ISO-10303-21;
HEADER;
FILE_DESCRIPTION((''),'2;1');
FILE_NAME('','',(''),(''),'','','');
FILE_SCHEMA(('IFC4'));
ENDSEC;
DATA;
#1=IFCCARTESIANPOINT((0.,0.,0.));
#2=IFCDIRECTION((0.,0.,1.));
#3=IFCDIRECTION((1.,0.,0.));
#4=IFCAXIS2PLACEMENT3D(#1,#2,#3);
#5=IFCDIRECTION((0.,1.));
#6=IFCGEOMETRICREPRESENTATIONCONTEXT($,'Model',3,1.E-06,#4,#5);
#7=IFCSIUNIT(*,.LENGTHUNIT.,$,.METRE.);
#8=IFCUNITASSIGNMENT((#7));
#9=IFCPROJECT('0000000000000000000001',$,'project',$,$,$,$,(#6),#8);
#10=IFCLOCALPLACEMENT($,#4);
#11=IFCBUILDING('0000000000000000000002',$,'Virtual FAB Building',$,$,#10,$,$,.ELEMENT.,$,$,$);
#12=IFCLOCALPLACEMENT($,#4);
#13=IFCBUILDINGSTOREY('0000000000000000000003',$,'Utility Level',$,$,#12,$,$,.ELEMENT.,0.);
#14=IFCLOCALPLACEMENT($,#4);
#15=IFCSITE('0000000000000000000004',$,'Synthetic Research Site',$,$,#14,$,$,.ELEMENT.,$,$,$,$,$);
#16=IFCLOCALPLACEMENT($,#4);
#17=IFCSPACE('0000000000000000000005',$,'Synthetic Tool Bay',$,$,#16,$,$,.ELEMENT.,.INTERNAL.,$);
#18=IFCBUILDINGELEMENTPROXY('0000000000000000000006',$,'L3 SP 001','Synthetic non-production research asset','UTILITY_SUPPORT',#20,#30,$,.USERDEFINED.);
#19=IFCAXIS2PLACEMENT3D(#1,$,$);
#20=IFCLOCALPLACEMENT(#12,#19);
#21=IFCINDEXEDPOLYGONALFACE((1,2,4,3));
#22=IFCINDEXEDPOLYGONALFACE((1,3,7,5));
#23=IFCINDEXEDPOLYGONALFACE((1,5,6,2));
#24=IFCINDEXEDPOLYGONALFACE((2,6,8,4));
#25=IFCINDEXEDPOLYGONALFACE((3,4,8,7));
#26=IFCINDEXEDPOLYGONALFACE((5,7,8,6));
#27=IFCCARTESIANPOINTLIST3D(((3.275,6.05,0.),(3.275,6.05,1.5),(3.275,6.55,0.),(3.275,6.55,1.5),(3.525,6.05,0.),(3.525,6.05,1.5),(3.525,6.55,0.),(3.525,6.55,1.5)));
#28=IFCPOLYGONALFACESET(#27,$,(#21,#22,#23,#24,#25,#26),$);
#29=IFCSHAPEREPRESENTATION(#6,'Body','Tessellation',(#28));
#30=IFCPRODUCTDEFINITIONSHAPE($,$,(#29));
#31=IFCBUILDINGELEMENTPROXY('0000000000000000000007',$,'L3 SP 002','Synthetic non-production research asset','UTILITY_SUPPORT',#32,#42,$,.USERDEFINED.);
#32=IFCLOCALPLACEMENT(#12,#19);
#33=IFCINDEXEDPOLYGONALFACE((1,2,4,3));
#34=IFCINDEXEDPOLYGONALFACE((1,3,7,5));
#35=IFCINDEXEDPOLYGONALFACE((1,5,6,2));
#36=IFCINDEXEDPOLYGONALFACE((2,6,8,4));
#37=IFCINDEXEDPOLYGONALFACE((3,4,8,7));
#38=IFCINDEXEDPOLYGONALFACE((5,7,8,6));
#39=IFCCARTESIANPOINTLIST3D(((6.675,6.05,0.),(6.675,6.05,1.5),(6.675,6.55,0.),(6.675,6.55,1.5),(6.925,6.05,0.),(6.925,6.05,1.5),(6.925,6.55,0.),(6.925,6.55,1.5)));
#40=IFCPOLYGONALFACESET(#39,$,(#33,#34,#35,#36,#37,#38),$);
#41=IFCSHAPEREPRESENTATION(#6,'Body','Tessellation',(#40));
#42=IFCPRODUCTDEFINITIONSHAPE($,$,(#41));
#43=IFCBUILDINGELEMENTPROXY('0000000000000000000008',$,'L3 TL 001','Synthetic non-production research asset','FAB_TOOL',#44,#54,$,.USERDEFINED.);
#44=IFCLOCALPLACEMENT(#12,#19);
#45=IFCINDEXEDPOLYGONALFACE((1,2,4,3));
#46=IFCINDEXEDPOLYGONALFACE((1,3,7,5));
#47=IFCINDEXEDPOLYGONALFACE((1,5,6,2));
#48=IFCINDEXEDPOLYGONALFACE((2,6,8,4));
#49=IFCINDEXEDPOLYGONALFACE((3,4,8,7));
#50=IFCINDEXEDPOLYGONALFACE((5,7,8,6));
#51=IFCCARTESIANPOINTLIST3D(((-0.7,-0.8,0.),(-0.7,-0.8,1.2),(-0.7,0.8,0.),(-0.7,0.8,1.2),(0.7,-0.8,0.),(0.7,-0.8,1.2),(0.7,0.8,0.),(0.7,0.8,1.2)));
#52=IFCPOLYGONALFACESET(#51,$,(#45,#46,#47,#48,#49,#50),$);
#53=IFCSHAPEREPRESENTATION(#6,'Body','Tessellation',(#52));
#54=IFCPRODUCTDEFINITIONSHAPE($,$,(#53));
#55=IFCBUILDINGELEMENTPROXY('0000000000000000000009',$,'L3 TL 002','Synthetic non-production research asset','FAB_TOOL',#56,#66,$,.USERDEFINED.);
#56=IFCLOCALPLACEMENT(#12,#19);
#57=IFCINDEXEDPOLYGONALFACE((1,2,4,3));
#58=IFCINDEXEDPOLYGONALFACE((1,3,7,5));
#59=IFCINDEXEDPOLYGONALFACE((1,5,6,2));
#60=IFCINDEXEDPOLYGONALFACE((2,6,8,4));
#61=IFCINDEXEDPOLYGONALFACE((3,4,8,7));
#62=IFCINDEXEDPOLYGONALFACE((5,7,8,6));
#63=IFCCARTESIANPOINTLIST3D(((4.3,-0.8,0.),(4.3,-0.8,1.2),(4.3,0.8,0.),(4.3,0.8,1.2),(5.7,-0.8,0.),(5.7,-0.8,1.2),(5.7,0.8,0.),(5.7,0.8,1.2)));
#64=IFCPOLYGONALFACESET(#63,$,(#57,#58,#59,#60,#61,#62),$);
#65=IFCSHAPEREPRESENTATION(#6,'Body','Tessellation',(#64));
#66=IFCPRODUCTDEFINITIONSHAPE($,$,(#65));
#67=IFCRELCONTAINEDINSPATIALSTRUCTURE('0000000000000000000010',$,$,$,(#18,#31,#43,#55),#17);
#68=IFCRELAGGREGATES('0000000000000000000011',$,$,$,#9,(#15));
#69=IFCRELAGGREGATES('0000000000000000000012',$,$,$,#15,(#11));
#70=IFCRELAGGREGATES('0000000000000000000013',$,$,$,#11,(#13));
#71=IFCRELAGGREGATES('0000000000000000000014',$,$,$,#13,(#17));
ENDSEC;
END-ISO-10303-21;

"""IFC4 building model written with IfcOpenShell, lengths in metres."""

from ifc_helpers import new_model, si_unit, direction, frame, origin_with_axes, origin_2d_with_axis, place, context, project, spatial, rectangle, extrude, element, save


model = new_model("IFC4")

# Units and contexts
model_context = context("Model", 3, precision=1e-06, world=origin_with_axes(), true_north=direction((0.0, 1.0)))
ifc_project = project(units=[si_unit("LENGTHUNIT", "METRE")], contexts=[model_context])

# Site, building, storey, space
site_placement = place(None, origin_with_axes())
site = spatial("IfcSite", under=ifc_project, at=site_placement, Name="Synthetic Research Site", CompositionType="ELEMENT")
building_placement = place(None, origin_with_axes())
building = spatial("IfcBuilding", under=site, at=building_placement, Name="Virtual FAB Building", CompositionType="ELEMENT")
storey_placement = place(None, origin_with_axes())
storey = spatial("IfcBuildingStorey", under=building, at=storey_placement, Name="Utility Level", CompositionType="ELEMENT", Elevation=0.0)
space_placement = place(None, origin_with_axes())
space = spatial("IfcSpace", under=storey, at=space_placement, Name="Synthetic Tool Bay", CompositionType="ELEMENT", PredefinedType="INTERNAL")

# Building element proxies
for number, where, z_axis, x_axis, name in (
    (1, (3.4, 6.3, 0.0), (0.0, 0.0, 1.0), (1.0, 0.0, 0.0), "L3 SP 001"),
    (2, (6.8, 6.3, 0.0), (0.0, 0.0, 1.0), (1.0, 0.0, 0.0), "L3 SP 002"),
):
    element("IfcBuildingElementProxy", number, at=place(None, frame(where, z_axis=z_axis, x_axis=x_axis)), inside=space, Name=name, Description="Synthetic non-production research asset", ObjectType="UTILITY_SUPPORT", PredefinedType="USERDEFINED", context=model_context, shape_type="SweptSolid", body=[
        extrude(rectangle(XDim=0.25, YDim=0.5, at=origin_2d_with_axis()), origin_with_axes(), (0.0, 0.0, 1.0), 1.5),
    ])
for number, where, z_axis, x_axis, name in (
    (3, (0.0, 0.0, 0.0), (0.0, 0.0, 1.0), (1.0, 0.0, 0.0), "L3 TL 001"),
    (4, (5.0, 0.0, 0.0), (0.0, 0.0, 1.0), (1.0, 0.0, 0.0), "L3 TL 002"),
):
    element("IfcBuildingElementProxy", number, at=place(None, frame(where, z_axis=z_axis, x_axis=x_axis)), inside=space, Name=name, Description="Synthetic non-production research asset", ObjectType="FAB_TOOL", PredefinedType="USERDEFINED", context=model_context, shape_type="SweptSolid", body=[
        extrude(rectangle(XDim=1.4, YDim=1.6, at=origin_2d_with_axis()), origin_with_axes(), (0.0, 0.0, 1.0), 1.2),
    ])

save(model, "model.ifc")
